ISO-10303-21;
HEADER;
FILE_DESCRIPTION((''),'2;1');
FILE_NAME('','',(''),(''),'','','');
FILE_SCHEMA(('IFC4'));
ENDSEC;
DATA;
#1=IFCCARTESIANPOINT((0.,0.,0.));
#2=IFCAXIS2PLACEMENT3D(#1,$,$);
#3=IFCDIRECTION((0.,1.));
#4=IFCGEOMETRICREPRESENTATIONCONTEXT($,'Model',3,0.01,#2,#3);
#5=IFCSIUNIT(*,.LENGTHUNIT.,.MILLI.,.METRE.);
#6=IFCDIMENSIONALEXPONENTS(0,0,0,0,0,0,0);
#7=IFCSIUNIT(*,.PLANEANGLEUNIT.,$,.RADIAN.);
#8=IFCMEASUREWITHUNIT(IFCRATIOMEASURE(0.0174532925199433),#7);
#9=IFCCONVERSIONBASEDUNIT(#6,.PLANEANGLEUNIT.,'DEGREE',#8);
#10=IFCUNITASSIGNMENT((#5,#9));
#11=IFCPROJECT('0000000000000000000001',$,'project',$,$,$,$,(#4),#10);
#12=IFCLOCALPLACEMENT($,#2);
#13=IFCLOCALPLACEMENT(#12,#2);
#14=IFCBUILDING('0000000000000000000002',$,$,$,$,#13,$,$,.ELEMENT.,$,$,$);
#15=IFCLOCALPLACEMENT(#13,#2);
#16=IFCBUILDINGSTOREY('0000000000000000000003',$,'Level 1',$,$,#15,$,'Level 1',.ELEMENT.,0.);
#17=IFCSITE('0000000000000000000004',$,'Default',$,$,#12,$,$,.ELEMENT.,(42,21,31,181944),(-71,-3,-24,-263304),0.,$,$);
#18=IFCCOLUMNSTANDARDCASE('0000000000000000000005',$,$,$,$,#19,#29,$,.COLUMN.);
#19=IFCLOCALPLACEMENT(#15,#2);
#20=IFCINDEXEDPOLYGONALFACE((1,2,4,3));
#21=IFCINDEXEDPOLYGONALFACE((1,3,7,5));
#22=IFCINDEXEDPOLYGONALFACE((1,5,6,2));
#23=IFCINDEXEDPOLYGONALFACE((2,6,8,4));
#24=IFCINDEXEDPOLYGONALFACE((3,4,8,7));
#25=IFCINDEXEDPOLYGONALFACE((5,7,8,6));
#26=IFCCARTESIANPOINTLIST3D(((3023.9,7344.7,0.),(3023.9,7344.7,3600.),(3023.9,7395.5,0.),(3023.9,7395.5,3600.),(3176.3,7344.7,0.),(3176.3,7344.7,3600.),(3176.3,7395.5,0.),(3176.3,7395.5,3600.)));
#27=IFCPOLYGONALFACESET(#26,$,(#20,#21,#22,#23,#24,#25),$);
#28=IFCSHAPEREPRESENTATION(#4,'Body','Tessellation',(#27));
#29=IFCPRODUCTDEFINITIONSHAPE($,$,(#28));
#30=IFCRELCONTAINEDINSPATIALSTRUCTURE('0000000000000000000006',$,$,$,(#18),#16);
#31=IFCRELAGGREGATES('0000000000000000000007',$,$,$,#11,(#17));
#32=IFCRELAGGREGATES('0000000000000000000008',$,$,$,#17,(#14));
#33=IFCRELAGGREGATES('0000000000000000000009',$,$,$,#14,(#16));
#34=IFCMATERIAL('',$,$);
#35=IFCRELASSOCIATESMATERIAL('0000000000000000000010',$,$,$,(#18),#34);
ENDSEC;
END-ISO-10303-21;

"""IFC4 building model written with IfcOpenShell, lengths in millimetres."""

from ifc_helpers import new_model, entity, si_unit, converted_unit, direction, frame, origin, place, context, project, spatial, rectangle, extrude, material, element, save


model = new_model("IFC4")

# Units and contexts
model_context = context("Model", 3, precision=0.01, world=origin(), true_north=direction((0.0, 1.0)))
ifc_project = project(units=[si_unit("LENGTHUNIT", "METRE", prefix="MILLI"), converted_unit("PLANEANGLEUNIT", "DEGREE", entity("IfcRatioMeasure", 0.0174532925199433), si_unit("PLANEANGLEUNIT", "RADIAN"), dimensions=[0, 0, 0, 0, 0, 0, 0])], contexts=[model_context])

# Site, building, storey
site_placement = place(None, origin())
site = spatial("IfcSite", under=ifc_project, at=site_placement, Name="Default", CompositionType="ELEMENT", RefLatitude=(42, 21, 31, 181944), RefLongitude=(-71, -3, -24, -263304), RefElevation=0.0)
building_placement = place(site_placement, origin())
building = spatial("IfcBuilding", under=site, at=building_placement, CompositionType="ELEMENT")
storey_placement = place(building_placement, origin())
storey = spatial("IfcBuildingStorey", under=building, at=storey_placement, Name="Level 1", LongName="Level 1", CompositionType="ELEMENT", Elevation=0.0)

# Column
ifc_material_1 = material(Name="")
placement_1 = place(storey_placement, frame((3100.1, 7344.7, 0.0), z_axis=(0.0, 0.0, 1.0), x_axis=(0.0, 1.0, 0.0)))
column_placement = place(placement_1, frame((25.4, 0.0, 0.0), z_axis=(0.0, 0.0, 1.0), x_axis=(1.0, 0.0, 0.0)))
element("IfcColumnStandardCase", 1, at=column_placement, inside=storey, material=ifc_material_1, PredefinedType="COLUMN", context=model_context, shape_type="SweptSolid", body=[
    extrude(rectangle(XDim=50.8, YDim=152.4), origin(), (0.0, 0.0, 1.0), 3600.0),
])

save(model, "model.ifc")
